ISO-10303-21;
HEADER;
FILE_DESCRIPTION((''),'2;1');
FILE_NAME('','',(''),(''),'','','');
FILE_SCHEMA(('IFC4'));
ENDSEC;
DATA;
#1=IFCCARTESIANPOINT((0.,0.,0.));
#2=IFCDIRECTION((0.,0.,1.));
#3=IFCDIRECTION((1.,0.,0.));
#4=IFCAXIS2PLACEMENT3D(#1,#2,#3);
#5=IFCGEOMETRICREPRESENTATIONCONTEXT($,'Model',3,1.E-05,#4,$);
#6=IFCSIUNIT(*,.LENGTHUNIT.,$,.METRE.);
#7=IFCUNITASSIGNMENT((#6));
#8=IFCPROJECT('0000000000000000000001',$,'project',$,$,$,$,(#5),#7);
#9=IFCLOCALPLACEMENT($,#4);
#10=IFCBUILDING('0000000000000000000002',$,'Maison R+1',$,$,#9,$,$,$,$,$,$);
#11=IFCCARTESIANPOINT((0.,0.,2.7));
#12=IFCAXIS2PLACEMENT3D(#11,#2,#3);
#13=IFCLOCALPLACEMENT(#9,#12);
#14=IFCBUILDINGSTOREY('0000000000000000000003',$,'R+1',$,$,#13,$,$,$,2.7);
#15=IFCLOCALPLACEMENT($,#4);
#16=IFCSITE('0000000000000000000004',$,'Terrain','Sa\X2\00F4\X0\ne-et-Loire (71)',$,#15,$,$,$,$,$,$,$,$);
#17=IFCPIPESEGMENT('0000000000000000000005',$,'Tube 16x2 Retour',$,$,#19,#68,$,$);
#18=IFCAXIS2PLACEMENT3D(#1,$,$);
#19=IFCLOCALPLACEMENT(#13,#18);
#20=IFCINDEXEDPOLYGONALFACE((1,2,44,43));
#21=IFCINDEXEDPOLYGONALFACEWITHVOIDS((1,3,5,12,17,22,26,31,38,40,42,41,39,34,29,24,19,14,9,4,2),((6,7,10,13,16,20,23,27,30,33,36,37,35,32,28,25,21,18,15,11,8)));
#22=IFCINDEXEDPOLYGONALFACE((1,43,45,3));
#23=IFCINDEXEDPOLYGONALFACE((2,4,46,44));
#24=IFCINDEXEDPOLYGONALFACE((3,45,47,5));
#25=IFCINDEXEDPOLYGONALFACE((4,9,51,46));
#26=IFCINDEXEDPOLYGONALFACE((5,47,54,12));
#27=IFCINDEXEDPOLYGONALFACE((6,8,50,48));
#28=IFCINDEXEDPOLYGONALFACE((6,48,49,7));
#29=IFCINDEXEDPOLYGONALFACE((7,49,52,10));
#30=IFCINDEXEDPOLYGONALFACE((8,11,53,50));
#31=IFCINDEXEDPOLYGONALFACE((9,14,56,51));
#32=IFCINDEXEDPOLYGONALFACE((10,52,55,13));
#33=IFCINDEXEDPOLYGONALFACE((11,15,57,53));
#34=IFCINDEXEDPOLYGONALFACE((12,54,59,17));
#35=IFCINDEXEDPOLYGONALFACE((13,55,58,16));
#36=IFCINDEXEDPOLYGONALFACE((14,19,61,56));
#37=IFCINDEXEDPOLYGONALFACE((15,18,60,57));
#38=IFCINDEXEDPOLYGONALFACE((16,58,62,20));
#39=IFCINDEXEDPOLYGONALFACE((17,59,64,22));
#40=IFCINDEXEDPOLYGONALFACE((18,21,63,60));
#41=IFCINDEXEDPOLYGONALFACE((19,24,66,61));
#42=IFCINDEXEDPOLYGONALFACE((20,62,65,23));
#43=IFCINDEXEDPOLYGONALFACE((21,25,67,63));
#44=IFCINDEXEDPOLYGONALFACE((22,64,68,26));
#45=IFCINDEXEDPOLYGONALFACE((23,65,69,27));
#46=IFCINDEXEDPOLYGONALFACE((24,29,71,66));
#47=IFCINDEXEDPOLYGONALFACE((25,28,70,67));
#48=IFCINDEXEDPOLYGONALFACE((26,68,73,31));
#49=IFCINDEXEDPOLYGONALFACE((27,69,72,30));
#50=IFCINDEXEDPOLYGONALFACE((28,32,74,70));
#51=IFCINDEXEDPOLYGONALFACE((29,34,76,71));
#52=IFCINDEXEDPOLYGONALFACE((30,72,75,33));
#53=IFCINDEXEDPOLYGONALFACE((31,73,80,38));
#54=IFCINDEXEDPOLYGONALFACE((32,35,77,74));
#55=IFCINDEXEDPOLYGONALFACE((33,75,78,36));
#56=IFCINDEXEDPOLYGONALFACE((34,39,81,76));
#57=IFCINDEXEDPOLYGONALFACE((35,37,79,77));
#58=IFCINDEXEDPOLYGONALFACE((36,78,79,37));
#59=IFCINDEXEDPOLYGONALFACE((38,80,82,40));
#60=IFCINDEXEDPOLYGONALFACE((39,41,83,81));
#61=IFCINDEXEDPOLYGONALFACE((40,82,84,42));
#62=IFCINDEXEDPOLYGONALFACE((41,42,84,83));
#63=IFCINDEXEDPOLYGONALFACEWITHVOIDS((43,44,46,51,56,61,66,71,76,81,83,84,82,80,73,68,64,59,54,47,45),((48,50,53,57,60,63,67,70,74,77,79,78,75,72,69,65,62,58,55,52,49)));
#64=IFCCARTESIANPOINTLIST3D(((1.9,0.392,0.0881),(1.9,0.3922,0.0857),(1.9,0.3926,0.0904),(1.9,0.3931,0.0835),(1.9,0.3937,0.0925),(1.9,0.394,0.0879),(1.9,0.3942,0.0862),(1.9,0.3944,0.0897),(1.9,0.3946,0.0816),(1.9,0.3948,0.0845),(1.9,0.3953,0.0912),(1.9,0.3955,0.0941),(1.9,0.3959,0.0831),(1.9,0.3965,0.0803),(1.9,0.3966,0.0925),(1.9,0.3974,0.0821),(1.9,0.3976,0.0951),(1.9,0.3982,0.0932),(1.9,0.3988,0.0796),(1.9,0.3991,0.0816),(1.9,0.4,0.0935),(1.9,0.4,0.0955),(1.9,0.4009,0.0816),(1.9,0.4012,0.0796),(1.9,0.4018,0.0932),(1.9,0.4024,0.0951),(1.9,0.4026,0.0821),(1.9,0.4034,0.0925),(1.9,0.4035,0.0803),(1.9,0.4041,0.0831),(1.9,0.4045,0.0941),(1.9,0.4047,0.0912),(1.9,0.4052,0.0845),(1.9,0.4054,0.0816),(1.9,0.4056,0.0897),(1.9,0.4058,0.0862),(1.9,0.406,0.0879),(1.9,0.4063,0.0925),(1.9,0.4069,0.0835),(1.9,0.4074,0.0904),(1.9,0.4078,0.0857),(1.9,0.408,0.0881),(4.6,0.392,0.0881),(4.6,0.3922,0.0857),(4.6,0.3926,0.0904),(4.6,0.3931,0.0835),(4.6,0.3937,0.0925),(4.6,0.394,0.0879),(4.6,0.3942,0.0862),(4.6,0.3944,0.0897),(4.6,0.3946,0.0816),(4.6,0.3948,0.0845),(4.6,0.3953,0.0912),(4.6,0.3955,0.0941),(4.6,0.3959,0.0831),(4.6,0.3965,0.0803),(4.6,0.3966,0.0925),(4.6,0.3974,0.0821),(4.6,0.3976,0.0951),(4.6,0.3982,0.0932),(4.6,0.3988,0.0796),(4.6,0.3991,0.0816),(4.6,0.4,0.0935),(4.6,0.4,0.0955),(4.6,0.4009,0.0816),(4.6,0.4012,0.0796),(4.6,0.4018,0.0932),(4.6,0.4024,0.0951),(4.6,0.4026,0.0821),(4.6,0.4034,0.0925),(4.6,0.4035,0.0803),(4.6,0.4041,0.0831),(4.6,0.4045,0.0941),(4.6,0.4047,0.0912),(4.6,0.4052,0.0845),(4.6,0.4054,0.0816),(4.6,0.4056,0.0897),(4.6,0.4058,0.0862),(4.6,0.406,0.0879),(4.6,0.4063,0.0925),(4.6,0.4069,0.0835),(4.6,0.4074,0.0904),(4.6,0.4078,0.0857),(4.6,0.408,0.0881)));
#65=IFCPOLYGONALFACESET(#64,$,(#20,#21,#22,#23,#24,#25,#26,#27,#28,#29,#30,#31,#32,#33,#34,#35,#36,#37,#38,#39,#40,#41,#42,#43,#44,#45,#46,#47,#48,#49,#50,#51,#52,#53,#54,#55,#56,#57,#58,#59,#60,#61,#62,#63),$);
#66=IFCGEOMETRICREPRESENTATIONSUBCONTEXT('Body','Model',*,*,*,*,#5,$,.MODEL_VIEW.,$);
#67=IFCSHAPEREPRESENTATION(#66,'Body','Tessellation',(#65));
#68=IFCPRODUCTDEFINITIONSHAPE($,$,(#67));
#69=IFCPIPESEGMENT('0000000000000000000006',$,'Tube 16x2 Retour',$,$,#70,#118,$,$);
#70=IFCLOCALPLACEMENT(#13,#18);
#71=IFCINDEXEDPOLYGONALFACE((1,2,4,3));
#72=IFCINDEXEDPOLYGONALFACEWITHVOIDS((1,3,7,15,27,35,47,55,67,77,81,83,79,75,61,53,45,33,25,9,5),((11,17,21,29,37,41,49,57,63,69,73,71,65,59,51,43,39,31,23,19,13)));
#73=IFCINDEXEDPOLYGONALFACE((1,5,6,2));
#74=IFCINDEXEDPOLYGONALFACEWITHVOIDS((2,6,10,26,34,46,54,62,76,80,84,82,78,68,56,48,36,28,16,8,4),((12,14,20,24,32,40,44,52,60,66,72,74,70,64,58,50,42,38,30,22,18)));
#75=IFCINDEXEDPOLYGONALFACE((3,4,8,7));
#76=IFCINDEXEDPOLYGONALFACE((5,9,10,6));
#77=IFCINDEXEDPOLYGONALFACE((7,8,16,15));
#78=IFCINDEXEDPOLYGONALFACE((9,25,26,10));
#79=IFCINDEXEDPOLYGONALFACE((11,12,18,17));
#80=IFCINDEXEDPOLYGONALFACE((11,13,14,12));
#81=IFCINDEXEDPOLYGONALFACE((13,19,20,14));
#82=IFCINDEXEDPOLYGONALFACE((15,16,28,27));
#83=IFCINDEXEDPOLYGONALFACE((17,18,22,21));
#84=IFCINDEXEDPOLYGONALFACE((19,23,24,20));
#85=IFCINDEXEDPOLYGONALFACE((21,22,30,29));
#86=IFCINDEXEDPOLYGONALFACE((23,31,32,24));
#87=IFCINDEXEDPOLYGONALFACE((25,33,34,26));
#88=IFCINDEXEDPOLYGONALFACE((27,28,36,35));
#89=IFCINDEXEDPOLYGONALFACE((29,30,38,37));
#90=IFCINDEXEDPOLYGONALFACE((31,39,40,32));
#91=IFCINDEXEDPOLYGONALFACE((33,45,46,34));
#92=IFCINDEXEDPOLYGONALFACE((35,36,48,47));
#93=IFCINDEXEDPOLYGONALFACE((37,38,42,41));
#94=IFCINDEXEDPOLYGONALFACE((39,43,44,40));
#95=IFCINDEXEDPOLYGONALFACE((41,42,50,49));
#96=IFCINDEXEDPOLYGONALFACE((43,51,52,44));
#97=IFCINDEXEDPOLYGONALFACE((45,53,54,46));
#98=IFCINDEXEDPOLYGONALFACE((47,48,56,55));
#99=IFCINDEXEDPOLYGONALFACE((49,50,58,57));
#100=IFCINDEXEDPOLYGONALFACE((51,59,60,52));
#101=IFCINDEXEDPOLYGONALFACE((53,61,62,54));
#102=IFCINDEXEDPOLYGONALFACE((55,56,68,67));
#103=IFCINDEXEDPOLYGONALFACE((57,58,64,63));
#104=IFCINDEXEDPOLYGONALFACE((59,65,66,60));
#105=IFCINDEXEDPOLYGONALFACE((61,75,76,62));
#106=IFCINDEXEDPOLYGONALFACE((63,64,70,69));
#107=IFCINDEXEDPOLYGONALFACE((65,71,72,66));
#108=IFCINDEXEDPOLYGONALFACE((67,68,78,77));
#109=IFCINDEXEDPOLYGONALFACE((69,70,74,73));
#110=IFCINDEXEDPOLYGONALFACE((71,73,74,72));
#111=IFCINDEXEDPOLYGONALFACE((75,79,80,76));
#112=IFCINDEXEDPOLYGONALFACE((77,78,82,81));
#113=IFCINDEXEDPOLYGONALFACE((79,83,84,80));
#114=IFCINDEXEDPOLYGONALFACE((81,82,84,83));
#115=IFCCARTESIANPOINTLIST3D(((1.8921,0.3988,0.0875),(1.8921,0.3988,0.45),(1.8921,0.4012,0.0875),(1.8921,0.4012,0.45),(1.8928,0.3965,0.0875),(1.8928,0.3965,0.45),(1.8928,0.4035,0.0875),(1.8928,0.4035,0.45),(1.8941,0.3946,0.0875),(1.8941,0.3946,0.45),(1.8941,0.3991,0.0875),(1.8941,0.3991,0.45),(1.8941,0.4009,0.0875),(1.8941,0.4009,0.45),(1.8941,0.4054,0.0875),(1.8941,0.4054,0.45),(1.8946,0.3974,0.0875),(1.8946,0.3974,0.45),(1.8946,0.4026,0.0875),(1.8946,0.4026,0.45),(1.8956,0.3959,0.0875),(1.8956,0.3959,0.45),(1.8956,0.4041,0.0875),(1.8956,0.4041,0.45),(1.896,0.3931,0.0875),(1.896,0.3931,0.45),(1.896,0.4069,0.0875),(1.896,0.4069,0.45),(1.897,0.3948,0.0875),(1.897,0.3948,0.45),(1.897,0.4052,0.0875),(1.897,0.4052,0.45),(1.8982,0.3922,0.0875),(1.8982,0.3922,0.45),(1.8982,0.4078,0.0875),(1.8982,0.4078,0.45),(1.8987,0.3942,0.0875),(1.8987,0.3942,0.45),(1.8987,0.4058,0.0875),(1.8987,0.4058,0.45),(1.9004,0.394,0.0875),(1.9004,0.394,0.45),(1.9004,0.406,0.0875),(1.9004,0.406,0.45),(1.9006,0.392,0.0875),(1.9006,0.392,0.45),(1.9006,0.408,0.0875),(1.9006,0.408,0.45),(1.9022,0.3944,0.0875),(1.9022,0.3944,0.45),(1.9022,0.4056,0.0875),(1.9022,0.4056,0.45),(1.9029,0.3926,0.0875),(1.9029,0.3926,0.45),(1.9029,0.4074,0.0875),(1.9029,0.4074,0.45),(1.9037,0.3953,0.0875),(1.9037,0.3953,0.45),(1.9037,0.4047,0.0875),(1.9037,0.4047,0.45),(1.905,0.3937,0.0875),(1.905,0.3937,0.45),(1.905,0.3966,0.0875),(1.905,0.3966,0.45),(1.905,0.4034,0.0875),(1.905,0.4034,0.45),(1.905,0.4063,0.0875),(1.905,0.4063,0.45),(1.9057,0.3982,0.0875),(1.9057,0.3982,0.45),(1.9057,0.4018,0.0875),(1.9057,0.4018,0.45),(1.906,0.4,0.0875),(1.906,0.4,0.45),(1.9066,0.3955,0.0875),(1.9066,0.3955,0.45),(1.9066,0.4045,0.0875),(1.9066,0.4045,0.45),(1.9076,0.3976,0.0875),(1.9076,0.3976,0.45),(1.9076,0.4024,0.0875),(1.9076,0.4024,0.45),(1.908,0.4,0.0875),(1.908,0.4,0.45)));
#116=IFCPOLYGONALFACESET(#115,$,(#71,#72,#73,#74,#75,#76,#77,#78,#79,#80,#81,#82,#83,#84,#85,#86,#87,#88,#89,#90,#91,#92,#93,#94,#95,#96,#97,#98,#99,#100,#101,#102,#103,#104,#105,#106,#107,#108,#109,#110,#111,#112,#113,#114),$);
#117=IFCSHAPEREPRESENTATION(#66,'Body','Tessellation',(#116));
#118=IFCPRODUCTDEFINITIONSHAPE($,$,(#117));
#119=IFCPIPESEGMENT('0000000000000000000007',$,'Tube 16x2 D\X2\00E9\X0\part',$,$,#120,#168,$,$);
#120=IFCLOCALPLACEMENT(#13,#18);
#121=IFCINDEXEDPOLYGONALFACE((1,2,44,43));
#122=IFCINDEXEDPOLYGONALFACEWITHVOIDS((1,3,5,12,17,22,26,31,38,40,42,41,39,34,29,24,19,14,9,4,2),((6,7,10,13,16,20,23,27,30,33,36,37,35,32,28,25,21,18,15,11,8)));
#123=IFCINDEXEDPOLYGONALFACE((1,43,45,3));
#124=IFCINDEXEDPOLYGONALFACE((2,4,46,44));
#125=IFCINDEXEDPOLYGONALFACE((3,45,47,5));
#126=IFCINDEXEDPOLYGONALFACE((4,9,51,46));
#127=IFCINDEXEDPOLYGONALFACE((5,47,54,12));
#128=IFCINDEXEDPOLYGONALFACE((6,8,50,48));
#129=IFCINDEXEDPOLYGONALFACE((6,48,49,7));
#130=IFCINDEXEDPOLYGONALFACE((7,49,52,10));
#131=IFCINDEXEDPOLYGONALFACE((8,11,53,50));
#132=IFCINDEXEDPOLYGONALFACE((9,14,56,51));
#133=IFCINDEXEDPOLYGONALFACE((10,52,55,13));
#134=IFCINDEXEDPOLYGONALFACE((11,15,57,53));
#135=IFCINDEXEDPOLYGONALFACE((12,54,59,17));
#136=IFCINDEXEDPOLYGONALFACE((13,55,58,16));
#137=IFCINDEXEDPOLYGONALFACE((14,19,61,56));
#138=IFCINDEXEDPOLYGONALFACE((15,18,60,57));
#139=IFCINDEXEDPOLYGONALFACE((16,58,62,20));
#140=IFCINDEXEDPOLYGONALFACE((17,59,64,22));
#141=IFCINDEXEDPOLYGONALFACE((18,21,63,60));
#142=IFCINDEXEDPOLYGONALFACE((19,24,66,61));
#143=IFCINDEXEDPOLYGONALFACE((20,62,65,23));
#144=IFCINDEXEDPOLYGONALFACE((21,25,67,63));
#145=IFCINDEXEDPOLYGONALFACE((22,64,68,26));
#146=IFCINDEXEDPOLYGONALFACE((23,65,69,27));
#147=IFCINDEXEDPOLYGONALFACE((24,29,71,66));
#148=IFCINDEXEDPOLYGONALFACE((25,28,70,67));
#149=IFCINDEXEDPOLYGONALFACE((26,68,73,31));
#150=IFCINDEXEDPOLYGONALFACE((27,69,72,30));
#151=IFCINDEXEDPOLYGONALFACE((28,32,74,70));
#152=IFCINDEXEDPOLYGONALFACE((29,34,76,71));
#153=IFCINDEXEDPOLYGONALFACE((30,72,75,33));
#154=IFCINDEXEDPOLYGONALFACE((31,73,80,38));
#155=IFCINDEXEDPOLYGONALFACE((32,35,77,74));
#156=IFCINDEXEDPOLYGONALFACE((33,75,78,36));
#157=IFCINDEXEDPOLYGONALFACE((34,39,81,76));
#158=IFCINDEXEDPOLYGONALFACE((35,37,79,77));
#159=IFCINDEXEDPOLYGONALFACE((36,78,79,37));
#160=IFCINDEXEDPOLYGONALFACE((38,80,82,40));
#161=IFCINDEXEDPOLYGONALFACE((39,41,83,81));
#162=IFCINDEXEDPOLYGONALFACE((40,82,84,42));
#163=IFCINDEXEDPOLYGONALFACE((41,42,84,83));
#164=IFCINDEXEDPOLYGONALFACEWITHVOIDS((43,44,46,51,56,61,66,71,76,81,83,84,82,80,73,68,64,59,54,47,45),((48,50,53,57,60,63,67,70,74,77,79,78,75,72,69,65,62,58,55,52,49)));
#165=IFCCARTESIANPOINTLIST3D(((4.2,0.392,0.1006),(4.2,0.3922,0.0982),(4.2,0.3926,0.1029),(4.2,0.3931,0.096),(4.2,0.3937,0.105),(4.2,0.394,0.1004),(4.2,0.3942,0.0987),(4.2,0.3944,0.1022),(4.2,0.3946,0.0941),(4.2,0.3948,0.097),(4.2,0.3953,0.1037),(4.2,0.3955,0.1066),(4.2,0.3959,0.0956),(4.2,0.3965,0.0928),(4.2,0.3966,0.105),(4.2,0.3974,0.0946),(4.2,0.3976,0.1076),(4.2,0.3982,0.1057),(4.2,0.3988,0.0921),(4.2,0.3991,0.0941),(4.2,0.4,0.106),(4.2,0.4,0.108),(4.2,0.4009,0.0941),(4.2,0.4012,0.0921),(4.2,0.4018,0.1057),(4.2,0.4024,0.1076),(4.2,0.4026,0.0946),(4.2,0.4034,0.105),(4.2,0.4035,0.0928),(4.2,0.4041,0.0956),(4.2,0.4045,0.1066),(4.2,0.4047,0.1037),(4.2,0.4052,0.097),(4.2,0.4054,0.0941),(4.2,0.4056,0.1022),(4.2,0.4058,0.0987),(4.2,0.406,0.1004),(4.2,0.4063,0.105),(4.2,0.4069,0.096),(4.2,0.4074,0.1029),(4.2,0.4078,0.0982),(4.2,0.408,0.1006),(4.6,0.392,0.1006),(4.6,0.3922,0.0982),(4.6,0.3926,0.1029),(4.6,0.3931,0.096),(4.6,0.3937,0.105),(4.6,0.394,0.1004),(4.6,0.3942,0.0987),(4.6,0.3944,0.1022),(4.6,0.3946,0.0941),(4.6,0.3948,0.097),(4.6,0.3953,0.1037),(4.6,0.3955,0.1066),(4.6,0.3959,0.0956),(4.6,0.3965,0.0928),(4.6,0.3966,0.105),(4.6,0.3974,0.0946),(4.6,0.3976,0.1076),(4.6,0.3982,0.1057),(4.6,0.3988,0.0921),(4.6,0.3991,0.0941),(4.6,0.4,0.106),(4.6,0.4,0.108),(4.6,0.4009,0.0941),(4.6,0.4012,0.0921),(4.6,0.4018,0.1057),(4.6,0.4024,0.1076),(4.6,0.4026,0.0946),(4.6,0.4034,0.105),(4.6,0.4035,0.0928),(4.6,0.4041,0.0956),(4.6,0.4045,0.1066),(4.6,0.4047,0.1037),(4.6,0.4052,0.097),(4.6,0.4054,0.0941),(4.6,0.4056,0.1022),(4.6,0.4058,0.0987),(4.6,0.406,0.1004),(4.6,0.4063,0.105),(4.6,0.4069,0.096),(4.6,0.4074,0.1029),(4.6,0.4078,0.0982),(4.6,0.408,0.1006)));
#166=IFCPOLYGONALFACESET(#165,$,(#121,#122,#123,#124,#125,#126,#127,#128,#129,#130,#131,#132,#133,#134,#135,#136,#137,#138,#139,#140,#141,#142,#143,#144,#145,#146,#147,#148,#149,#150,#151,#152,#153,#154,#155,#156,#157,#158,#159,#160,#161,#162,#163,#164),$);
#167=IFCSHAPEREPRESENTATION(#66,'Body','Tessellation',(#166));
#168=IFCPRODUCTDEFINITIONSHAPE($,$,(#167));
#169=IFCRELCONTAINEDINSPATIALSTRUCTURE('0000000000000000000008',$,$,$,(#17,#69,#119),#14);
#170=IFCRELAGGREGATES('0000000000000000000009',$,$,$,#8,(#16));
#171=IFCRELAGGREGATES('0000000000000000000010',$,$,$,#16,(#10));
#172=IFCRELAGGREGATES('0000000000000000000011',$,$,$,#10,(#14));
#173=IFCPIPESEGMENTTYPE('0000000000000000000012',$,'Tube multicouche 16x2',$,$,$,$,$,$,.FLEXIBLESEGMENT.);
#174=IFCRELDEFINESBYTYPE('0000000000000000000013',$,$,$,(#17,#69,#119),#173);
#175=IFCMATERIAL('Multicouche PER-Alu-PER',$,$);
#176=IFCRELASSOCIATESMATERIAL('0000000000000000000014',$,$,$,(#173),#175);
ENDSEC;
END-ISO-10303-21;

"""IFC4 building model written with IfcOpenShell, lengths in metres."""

from ifc_helpers import new_model, si_unit, frame, origin_with_axes, place, context, subcontext, project, spatial, hollow_circle, extrude, material, type_object, element, save


model = new_model("IFC4")

# Units and contexts
model_context = context("Model", 3, precision=1e-05, world=origin_with_axes())
body_context = subcontext(model_context, "Body", "Model", "MODEL_VIEW")
ifc_project = project(units=[si_unit("LENGTHUNIT", "METRE")], contexts=[model_context])

# Site, building, storey
site_placement = place(None, origin_with_axes())
site = spatial("IfcSite", under=ifc_project, at=site_placement, Name="Terrain", Description="Saône-et-Loire (71)")
building_placement = place(None, origin_with_axes())
building = spatial("IfcBuilding", under=site, at=building_placement, Name="Maison R+1")
storey_placement = place(building_placement, frame((0.0, 0.0, 2.7), z_axis=(0.0, 0.0, 1.0), x_axis=(1.0, 0.0, 0.0)))
storey = spatial("IfcBuildingStorey", under=building, at=storey_placement, Name="R+1", Elevation=2.7)

# Pipe segments
ifc_material_1 = material(Name="Multicouche PER-Alu-PER")
pipe_segment_type = type_object("IfcPipeSegmentType", Name="Tube multicouche 16x2", PredefinedType="FLEXIBLESEGMENT", material=ifc_material_1)
pipe_segment_1_placement = place(storey_placement, frame((4.6, 0.4, 0.0875), z_axis=(-1.0, 0.0, 0.0), x_axis=(0.0, 0.0, 1.0)))
element("IfcPipeSegment", 1, at=pipe_segment_1_placement, inside=storey, type_object=pipe_segment_type, Name="Tube 16x2 Retour", context=body_context, shape_type="SweptSolid", body=[
    extrude(hollow_circle(Radius=0.008, WallThickness=0.002), origin_with_axes(), (0.0, 0.0, 1.0), 2.7),
])
pipe_segment_2_placement = place(storey_placement, frame((1.9, 0.4, 0.0875), z_axis=(0.0, 0.0, 1.0), x_axis=(1.0, 0.0, 0.0)))
element("IfcPipeSegment", 2, at=pipe_segment_2_placement, inside=storey, type_object=pipe_segment_type, Name="Tube 16x2 Retour", context=body_context, shape_type="SweptSolid", body=[
    extrude(hollow_circle(Radius=0.008, WallThickness=0.002), origin_with_axes(), (0.0, 0.0, 1.0), 0.3625),
])
pipe_segment_3_placement = place(storey_placement, frame((4.6, 0.4, 0.1), z_axis=(-1.0, 0.0, 0.0), x_axis=(0.0, 0.0, 1.0)))
element("IfcPipeSegment", 3, at=pipe_segment_3_placement, inside=storey, type_object=pipe_segment_type, Name="Tube 16x2 Départ", context=body_context, shape_type="SweptSolid", body=[
    extrude(hollow_circle(Radius=0.008, WallThickness=0.002), origin_with_axes(), (0.0, 0.0, 1.0), 0.4),
])

save(model, "model.ifc")
